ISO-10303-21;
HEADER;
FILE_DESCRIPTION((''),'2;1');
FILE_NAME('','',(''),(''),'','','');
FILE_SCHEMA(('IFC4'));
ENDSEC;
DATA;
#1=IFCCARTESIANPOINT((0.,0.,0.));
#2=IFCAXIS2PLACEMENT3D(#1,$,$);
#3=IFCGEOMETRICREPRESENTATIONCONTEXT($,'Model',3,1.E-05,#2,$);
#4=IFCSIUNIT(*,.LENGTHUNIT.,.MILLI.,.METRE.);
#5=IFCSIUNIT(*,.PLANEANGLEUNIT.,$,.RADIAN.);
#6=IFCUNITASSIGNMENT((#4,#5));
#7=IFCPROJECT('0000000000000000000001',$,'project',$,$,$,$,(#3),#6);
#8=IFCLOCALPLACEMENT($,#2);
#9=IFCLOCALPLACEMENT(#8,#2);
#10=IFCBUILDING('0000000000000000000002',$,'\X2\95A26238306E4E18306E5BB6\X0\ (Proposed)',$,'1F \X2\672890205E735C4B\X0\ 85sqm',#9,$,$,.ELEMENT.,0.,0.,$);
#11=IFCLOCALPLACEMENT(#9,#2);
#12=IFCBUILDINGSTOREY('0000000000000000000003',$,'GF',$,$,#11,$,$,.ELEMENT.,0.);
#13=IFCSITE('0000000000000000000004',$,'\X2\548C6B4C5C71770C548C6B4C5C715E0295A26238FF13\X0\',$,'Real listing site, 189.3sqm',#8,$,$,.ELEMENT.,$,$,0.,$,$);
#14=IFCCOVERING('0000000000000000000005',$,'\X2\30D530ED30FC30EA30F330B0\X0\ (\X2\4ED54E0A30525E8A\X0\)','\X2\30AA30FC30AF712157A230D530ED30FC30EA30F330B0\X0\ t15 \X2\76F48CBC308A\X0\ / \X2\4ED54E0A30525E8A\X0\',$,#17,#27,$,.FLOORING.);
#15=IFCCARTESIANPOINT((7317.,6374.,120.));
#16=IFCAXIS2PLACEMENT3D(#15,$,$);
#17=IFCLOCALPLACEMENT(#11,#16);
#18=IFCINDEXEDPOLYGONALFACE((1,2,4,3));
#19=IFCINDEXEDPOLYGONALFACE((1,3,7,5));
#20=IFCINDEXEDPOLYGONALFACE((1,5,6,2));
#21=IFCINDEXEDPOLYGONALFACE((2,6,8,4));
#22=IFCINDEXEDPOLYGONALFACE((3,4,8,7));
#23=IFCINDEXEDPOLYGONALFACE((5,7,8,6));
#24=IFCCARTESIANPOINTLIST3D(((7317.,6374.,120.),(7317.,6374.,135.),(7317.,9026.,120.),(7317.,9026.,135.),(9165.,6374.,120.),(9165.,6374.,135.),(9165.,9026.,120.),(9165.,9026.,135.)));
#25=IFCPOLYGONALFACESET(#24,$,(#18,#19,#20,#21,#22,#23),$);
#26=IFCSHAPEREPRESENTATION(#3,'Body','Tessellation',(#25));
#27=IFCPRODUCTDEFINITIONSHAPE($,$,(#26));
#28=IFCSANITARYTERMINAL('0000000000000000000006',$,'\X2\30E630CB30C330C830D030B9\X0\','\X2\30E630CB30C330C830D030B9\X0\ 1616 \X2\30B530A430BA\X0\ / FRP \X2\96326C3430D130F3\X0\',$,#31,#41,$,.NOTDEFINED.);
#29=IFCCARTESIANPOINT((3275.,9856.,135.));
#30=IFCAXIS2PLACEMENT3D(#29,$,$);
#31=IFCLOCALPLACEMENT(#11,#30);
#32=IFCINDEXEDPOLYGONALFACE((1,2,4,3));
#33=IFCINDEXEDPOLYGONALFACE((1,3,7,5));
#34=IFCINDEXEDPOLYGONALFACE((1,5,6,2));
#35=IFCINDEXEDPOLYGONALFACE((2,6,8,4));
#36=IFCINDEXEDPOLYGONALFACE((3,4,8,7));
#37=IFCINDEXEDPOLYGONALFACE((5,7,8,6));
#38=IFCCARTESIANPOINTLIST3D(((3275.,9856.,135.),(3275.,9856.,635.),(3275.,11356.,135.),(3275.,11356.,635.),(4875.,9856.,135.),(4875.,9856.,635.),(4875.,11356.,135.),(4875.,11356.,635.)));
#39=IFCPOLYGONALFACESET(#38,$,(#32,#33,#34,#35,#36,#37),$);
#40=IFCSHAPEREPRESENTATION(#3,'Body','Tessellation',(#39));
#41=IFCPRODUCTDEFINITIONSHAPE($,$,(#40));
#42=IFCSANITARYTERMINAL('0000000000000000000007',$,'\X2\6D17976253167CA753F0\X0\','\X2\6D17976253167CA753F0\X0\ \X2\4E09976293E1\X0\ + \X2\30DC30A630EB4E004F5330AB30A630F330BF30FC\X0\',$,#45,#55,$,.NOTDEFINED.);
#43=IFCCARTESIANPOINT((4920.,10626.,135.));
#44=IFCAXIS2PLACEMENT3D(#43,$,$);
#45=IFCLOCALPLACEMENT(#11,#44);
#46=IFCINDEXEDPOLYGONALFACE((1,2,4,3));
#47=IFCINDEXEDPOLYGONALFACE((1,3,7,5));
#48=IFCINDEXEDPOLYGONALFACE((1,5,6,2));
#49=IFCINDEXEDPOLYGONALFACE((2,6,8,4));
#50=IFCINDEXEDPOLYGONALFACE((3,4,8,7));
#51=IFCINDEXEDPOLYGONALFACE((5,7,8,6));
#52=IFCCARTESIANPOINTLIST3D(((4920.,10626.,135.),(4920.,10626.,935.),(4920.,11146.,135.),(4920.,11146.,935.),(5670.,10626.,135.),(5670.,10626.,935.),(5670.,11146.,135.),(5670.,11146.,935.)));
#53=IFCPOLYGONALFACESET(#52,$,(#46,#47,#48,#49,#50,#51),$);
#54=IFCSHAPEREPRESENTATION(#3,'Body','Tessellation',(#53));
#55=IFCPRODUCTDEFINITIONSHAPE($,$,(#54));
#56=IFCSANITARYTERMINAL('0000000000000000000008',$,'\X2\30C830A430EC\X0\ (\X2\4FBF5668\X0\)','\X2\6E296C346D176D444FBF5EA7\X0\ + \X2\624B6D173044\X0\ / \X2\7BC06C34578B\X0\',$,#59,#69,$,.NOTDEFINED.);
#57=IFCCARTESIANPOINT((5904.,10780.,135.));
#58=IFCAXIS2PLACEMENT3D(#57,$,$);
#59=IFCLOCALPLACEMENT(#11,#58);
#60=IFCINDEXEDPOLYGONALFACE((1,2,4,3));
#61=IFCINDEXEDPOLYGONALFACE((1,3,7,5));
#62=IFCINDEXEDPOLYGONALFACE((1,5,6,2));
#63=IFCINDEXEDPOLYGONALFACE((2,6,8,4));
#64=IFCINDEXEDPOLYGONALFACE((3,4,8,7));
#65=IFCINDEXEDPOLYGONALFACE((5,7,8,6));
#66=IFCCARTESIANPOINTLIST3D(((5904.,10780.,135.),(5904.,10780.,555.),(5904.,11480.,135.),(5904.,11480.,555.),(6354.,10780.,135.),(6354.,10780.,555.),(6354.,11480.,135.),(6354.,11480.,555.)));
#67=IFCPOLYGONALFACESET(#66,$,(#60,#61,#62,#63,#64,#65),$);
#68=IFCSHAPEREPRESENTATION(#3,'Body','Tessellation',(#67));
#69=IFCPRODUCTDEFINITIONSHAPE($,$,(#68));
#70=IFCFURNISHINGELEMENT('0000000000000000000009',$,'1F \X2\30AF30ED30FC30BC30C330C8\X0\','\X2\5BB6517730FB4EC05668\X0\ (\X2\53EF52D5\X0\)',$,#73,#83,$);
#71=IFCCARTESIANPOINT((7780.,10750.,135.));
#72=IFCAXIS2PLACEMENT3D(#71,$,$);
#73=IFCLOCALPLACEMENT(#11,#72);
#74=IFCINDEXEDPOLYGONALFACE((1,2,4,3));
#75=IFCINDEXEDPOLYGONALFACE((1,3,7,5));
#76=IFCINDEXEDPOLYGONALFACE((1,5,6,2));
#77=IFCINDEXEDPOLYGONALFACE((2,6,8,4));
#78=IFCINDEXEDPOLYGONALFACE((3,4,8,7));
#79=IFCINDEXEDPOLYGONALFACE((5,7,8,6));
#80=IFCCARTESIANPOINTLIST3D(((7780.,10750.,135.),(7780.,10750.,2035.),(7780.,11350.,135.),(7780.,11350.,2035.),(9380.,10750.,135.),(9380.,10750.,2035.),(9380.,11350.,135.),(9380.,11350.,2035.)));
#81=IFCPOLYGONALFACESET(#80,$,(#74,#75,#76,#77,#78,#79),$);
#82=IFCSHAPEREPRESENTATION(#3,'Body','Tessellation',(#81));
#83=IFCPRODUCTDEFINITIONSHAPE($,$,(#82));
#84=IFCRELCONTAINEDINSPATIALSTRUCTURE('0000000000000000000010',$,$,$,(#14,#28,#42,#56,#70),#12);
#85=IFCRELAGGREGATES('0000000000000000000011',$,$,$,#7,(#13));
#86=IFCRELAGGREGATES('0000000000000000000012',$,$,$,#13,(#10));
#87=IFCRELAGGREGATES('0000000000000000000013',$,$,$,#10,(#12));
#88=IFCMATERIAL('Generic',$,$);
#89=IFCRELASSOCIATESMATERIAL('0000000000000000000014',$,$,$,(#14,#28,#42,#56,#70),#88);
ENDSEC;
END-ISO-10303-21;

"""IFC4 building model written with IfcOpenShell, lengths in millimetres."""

from ifc_helpers import new_model, si_unit, frame, frame_2d, origin, place, context, project, spatial, rectangle, extrude, material, element, save


model = new_model("IFC4")

# Units and contexts
model_context = context("Model", 3, precision=1e-05, world=origin())
ifc_project = project(units=[si_unit("LENGTHUNIT", "METRE", prefix="MILLI"), si_unit("PLANEANGLEUNIT", "RADIAN")], contexts=[model_context])

# Site, building, storey
site_placement = place(None, origin())
site = spatial("IfcSite", under=ifc_project, at=site_placement, Name="和歌山県和歌山市関戸３", ObjectType="Real listing site, 189.3sqm", CompositionType="ELEMENT", RefElevation=0.0)
building_placement = place(site_placement, origin())
building = spatial("IfcBuilding", under=site, at=building_placement, Name="関戸の丘の家 (Proposed)", ObjectType="1F 木造平屋 85sqm", CompositionType="ELEMENT", ElevationOfRefHeight=0.0, ElevationOfTerrain=0.0)
storey_placement = place(building_placement, origin())
storey = spatial("IfcBuildingStorey", under=building, at=storey_placement, Name="GF", CompositionType="ELEMENT", Elevation=0.0)

# Covering
ifc_material_1 = material(Name="Generic")
covering_1_placement = place(storey_placement, frame((7317.0, 6374.0, 120.0)))
element("IfcCovering", 1, at=covering_1_placement, inside=storey, material=ifc_material_1, Name="フローリング (仕上げ床)", Description="オーク無垢フローリング t15 直貼り / 仕上げ床", PredefinedType="FLOORING", context=model_context, shape_type="SweptSolid", body=[
    extrude(rectangle(XDim=1848.0, YDim=2652.0, at=frame_2d((924.0, 1326.0))), frame((7317.0, 6374.0, 120.0)), (0.0, 0.0, 1.0), 15.0),
])

# Sanitary terminals
sanitary_terminal_1_placement = place(storey_placement, frame((3275.0, 9856.0, 135.0)))
element("IfcSanitaryTerminal", 2, at=sanitary_terminal_1_placement, inside=storey, material=ifc_material_1, Name="ユニットバス", Description="ユニットバス 1616 サイズ / FRP 防水パン", PredefinedType="NOTDEFINED", context=model_context, shape_type="SweptSolid", body=[
    extrude(rectangle(XDim=1600.0, YDim=1500.0, at=frame_2d((800.0, 750.0))), frame((3275.0, 9856.0, 135.0)), (0.0, 0.0, 1.0), 500.0),
])
sanitary_terminal_2_placement = place(storey_placement, frame((4920.0, 10626.0, 135.0)))
element("IfcSanitaryTerminal", 3, at=sanitary_terminal_2_placement, inside=storey, material=ifc_material_1, Name="洗面化粧台", Description="洗面化粧台 三面鏡 + ボウル一体カウンター", PredefinedType="NOTDEFINED", context=model_context, shape_type="SweptSolid", body=[
    extrude(rectangle(XDim=750.0, YDim=520.0, at=frame_2d((375.0, 260.0))), frame((4920.0, 10626.0, 135.0)), (0.0, 0.0, 1.0), 800.0),
])
sanitary_terminal_3_placement = place(storey_placement, frame((5904.0, 10780.0, 135.0)))
element("IfcSanitaryTerminal", 4, at=sanitary_terminal_3_placement, inside=storey, material=ifc_material_1, Name="トイレ (便器)", Description="温水洗浄便座 + 手洗い / 節水型", PredefinedType="NOTDEFINED", context=model_context, shape_type="SweptSolid", body=[
    extrude(rectangle(XDim=450.0, YDim=700.0, at=frame_2d((225.0, 350.0))), frame((5904.0, 10780.0, 135.0)), (0.0, 0.0, 1.0), 420.0),
])

# Furnishing element
furnishing_placement = place(storey_placement, frame((7780.0, 10750.0, 135.0)))
element("IfcFurnishingElement", 5, at=furnishing_placement, inside=storey, material=ifc_material_1, Name="1F クローゼット", Description="家具・什器 (可動)", context=model_context, shape_type="SweptSolid", body=[
    extrude(rectangle(XDim=1600.0, YDim=600.0, at=frame_2d((800.0, 300.0))), frame((7780.0, 10750.0, 135.0)), (0.0, 0.0, 1.0), 1900.0),
])

save(model, "model.ifc")
